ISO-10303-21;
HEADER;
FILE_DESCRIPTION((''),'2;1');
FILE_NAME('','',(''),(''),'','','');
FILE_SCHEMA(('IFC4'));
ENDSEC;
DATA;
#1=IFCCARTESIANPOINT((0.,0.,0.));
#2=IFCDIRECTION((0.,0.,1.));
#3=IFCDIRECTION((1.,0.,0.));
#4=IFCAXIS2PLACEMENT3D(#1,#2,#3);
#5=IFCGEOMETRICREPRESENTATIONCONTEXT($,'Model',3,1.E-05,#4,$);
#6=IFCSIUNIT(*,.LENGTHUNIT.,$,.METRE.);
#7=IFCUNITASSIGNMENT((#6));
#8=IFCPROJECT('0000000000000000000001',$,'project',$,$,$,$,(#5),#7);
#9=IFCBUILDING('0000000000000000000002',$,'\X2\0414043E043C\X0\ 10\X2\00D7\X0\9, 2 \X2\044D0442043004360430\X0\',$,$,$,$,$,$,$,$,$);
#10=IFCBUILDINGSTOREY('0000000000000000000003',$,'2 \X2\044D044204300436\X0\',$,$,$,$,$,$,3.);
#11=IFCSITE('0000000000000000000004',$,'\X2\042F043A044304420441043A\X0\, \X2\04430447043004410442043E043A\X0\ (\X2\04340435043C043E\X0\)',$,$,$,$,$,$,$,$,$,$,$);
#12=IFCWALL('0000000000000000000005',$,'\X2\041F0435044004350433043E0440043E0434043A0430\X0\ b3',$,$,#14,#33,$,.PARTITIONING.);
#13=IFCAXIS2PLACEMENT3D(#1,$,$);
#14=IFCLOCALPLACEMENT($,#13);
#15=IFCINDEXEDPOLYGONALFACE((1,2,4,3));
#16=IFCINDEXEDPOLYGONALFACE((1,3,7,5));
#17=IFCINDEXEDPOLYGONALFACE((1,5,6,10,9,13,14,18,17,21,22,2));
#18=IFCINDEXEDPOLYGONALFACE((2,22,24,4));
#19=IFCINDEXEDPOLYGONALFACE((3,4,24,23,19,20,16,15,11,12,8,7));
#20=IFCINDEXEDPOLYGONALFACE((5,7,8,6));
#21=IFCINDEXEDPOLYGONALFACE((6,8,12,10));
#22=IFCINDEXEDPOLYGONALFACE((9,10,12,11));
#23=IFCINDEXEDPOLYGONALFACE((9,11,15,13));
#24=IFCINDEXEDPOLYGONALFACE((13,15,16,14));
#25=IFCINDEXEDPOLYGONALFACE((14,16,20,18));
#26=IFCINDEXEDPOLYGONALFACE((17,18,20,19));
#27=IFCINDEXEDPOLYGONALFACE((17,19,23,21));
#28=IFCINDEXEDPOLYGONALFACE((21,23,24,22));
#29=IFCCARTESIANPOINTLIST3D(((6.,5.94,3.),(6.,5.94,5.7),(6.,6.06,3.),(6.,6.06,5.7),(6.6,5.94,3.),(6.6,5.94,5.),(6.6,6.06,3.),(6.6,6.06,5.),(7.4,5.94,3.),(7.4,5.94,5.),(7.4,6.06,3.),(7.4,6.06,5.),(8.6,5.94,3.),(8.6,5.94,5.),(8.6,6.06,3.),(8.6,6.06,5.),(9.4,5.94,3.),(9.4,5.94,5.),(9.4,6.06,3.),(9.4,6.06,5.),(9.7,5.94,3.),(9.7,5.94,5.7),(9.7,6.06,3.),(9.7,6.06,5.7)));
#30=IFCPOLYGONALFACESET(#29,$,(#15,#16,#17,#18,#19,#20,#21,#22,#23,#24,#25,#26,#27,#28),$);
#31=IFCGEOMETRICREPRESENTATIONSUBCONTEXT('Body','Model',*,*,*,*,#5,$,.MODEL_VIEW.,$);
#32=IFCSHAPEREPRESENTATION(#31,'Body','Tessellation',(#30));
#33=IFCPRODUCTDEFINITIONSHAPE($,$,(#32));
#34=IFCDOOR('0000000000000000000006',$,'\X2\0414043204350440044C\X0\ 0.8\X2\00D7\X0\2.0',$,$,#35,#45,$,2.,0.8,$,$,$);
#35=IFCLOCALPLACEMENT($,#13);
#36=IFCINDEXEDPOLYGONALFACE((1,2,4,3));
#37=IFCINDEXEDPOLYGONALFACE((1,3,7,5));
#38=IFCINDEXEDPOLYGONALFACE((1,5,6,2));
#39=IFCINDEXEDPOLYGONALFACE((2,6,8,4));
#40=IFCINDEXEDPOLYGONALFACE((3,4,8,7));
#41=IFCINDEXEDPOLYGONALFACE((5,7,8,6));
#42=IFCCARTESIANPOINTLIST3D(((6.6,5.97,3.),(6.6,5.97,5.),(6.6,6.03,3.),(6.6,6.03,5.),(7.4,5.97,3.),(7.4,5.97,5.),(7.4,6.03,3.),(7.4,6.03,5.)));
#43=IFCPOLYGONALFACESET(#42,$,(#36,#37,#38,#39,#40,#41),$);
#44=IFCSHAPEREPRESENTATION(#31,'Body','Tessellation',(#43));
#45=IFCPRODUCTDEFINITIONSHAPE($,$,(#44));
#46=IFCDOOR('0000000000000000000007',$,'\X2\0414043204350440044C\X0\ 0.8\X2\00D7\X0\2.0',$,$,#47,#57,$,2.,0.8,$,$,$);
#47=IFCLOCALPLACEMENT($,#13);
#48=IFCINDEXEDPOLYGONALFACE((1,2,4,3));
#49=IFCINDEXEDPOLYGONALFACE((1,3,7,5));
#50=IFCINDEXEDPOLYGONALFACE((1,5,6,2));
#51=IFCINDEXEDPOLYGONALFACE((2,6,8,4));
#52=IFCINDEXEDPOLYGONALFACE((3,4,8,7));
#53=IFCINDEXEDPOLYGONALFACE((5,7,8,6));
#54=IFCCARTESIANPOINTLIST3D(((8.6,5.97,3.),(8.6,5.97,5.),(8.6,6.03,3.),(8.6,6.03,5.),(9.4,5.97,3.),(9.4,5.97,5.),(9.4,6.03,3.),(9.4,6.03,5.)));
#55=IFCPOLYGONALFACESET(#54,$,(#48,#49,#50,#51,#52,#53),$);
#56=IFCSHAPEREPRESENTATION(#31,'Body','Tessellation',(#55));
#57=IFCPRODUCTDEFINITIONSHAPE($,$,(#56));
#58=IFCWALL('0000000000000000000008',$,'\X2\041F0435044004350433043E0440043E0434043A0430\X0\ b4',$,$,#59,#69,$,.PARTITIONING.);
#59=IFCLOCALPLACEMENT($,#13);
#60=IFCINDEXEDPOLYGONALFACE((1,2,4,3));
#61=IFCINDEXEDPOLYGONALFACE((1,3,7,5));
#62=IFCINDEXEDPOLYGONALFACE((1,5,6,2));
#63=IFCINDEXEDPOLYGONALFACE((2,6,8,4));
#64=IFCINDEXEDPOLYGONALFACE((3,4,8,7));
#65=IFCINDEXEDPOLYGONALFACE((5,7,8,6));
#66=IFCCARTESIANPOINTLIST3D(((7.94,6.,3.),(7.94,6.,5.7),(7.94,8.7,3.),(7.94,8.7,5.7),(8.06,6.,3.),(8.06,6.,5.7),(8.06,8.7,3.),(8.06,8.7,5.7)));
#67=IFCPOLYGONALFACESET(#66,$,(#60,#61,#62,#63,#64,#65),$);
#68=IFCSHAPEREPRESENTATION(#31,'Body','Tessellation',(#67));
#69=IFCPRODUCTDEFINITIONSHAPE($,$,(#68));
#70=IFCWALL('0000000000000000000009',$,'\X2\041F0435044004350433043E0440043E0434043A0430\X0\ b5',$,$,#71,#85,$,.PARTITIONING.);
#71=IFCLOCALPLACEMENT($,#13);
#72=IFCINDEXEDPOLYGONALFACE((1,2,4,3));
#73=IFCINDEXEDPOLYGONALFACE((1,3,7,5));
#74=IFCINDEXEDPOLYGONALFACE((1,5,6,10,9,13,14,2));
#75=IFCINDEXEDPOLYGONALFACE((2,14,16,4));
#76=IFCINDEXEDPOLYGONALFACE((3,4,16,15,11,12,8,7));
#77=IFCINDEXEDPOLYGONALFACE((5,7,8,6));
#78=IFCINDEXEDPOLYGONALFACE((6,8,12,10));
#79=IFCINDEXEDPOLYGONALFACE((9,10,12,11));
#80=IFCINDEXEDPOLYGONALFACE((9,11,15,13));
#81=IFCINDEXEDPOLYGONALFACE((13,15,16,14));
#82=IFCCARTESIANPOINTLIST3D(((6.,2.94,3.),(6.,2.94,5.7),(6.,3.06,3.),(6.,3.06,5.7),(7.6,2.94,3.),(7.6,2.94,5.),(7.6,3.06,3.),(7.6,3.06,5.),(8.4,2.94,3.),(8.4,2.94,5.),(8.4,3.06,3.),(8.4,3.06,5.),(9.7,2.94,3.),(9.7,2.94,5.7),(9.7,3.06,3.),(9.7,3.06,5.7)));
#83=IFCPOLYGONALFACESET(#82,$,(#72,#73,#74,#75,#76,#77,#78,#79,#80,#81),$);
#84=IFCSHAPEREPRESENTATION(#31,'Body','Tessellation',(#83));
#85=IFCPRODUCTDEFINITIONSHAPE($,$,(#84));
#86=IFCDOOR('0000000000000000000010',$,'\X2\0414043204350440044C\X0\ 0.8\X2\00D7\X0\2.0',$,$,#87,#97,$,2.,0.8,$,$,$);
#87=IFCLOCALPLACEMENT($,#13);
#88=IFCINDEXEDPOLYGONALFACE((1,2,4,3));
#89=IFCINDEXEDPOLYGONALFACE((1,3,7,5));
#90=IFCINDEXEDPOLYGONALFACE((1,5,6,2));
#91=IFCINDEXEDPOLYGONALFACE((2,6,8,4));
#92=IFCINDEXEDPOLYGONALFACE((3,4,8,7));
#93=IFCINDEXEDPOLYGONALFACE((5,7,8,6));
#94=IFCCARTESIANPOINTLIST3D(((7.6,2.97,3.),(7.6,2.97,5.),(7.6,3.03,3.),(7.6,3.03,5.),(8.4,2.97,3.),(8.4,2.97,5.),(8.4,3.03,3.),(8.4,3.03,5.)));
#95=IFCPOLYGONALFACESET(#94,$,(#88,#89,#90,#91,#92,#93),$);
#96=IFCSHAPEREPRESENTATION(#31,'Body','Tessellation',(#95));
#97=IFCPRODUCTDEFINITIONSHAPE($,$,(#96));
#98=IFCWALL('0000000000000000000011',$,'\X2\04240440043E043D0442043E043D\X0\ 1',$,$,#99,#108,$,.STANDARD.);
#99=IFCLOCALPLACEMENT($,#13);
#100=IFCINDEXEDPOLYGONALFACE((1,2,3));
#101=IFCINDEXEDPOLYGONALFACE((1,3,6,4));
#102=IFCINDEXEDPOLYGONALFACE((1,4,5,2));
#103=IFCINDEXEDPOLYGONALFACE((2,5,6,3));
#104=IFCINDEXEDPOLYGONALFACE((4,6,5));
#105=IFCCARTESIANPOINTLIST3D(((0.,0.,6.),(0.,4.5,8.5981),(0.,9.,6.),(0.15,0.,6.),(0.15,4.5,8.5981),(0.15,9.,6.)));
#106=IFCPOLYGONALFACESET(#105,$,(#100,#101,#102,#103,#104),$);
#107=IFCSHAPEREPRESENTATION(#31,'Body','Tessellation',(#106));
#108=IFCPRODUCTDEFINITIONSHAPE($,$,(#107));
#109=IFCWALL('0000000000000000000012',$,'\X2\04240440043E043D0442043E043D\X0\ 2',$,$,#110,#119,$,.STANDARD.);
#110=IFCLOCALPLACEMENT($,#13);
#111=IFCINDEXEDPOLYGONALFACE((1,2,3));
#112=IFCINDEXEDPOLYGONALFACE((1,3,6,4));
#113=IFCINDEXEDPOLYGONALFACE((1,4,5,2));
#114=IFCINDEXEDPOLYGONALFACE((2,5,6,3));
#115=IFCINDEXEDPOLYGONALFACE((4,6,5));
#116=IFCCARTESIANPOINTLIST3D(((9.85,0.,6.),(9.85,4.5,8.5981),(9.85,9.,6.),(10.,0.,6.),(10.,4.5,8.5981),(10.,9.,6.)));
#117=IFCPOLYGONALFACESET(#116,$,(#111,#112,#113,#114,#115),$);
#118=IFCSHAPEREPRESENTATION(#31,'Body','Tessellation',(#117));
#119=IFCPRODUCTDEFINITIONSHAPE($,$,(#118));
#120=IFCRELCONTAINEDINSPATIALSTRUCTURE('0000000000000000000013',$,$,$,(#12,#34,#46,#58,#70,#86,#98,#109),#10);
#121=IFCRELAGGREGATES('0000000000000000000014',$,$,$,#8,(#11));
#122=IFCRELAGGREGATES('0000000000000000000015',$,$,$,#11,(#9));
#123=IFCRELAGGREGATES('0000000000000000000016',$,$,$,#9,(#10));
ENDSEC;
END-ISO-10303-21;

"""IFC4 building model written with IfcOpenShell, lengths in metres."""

from ifc_helpers import new_model, si_unit, frame, origin_with_axes, place, context, subcontext, project, spatial, polyline, indexed_curve, outline, extrude, element, fill, save


model = new_model("IFC4")

# Units and contexts
model_context = context("Model", 3, precision=1e-05, world=origin_with_axes())
body_context = subcontext(model_context, "Body", "Model", "MODEL_VIEW")
ifc_project = project(units=[si_unit("LENGTHUNIT", "METRE")], contexts=[model_context])

# Site, building, storey
site = spatial("IfcSite", under=ifc_project, Name="Якутск, участок (демо)")
building = spatial("IfcBuilding", under=site, Name="Дом 10×9, 2 этажа")
storey = spatial("IfcBuildingStorey", under=building, Name="2 этаж", Elevation=3.0)

# Wall, openings, doors
wall_1_placement = place(None, frame((6.0, 5.94, 3.0), z_axis=(0.0, 0.0, 1.0), x_axis=(1.0, 0.0, 0.0)))
wall_1 = element("IfcWall", 1, at=wall_1_placement, inside=storey, Name="Перегородка b3", PredefinedType="PARTITIONING", context=body_context, shape_type="SweptSolid", body=[
    extrude(outline(indexed_curve([(0.0, 0.0), (0.0, 0.12), (3.7, 0.12), (3.7, 0.0), (0.0, 0.0)], self_intersect=False)), origin_with_axes(), (0.0, 0.0, 1.0), 2.7),
])
opening_1_placement = place(wall_1_placement, frame((0.6, -0.05, 0.0), z_axis=(0.0, 0.0, 1.0), x_axis=(1.0, 0.0, 0.0)))
opening_1 = element("IfcOpeningElement", 2, at=opening_1_placement, cuts=wall_1, context=body_context, shape_type="SweptSolid", body=[
    extrude(outline(indexed_curve([(0.0, 0.0), (0.0, 0.22), (0.8, 0.22), (0.8, 0.0), (0.0, 0.0)], self_intersect=False)), origin_with_axes(), (0.0, 0.0, 1.0), 2.0),
])
opening_2_placement = place(wall_1_placement, frame((2.6, -0.05, 0.0), z_axis=(0.0, 0.0, 1.0), x_axis=(1.0, 0.0, 0.0)))
opening_2 = element("IfcOpeningElement", 3, at=opening_2_placement, cuts=wall_1, context=body_context, shape_type="SweptSolid", body=[
    extrude(outline(indexed_curve([(0.0, 0.0), (0.0, 0.22), (0.8, 0.22), (0.8, 0.0), (0.0, 0.0)], self_intersect=False)), origin_with_axes(), (0.0, 0.0, 1.0), 2.0),
])
door_1_placement = place(opening_1_placement, frame((0.0, 0.08, 0.0), z_axis=(0.0, 0.0, 1.0), x_axis=(1.0, 0.0, 0.0)))
door_1 = element("IfcDoor", 4, at=door_1_placement, inside=storey, Name="Дверь 0.8×2.0", OverallHeight=2.0, OverallWidth=0.8, context=body_context, shape_type="SweptSolid", body=[
    extrude(outline(indexed_curve([(0.0, 0.0), (0.0, 0.06), (0.8, 0.06), (0.8, 0.0), (0.0, 0.0)], self_intersect=False)), origin_with_axes(), (0.0, 0.0, 1.0), 2.0),
])
fill(opening_1, door_1)
door_2_placement = place(opening_2_placement, frame((0.0, 0.08, 0.0), z_axis=(0.0, 0.0, 1.0), x_axis=(1.0, 0.0, 0.0)))
door_2 = element("IfcDoor", 5, at=door_2_placement, inside=storey, Name="Дверь 0.8×2.0", OverallHeight=2.0, OverallWidth=0.8, context=body_context, shape_type="SweptSolid", body=[
    extrude(outline(indexed_curve([(0.0, 0.0), (0.0, 0.06), (0.8, 0.06), (0.8, 0.0), (0.0, 0.0)], self_intersect=False)), origin_with_axes(), (0.0, 0.0, 1.0), 2.0),
])
fill(opening_2, door_2)

# Wall
wall_2_placement = place(None, frame((8.06, 6.0, 3.0), z_axis=(0.0, 0.0, 1.0), x_axis=(0.0, 1.0, 0.0)))
element("IfcWall", 6, at=wall_2_placement, inside=storey, Name="Перегородка b4", PredefinedType="PARTITIONING", context=body_context, shape_type="SweptSolid", body=[
    extrude(outline(indexed_curve([(0.0, 0.0), (0.0, 0.12), (2.7, 0.12), (2.7, 0.0), (0.0, 0.0)], self_intersect=False)), origin_with_axes(), (0.0, 0.0, 1.0), 2.7),
])

# Wall, opening, door
wall_3_placement = place(None, frame((6.0, 2.94, 3.0), z_axis=(0.0, 0.0, 1.0), x_axis=(1.0, 0.0, 0.0)))
wall_3 = element("IfcWall", 7, at=wall_3_placement, inside=storey, Name="Перегородка b5", PredefinedType="PARTITIONING", context=body_context, shape_type="SweptSolid", body=[
    extrude(outline(indexed_curve([(0.0, 0.0), (0.0, 0.12), (3.7, 0.12), (3.7, 0.0), (0.0, 0.0)], self_intersect=False)), origin_with_axes(), (0.0, 0.0, 1.0), 2.7),
])
opening_3_placement = place(wall_3_placement, frame((1.6, -0.05, 0.0), z_axis=(0.0, 0.0, 1.0), x_axis=(1.0, 0.0, 0.0)))
opening_3 = element("IfcOpeningElement", 8, at=opening_3_placement, cuts=wall_3, context=body_context, shape_type="SweptSolid", body=[
    extrude(outline(indexed_curve([(0.0, 0.0), (0.0, 0.22), (0.8, 0.22), (0.8, 0.0), (0.0, 0.0)], self_intersect=False)), origin_with_axes(), (0.0, 0.0, 1.0), 2.0),
])
door_3_placement = place(opening_3_placement, frame((0.0, 0.08, 0.0), z_axis=(0.0, 0.0, 1.0), x_axis=(1.0, 0.0, 0.0)))
door_3 = element("IfcDoor", 9, at=door_3_placement, inside=storey, Name="Дверь 0.8×2.0", OverallHeight=2.0, OverallWidth=0.8, context=body_context, shape_type="SweptSolid", body=[
    extrude(outline(indexed_curve([(0.0, 0.0), (0.0, 0.06), (0.8, 0.06), (0.8, 0.0), (0.0, 0.0)], self_intersect=False)), origin_with_axes(), (0.0, 0.0, 1.0), 2.0),
])
fill(opening_3, door_3)

# Walls
for number, where, z_axis, x_axis, name in (
    (10, (0.0, 0.0, 6.0), (1.0, 0.0, 0.0), (0.0, 1.0, 0.0), "Фронтон 1"),
    (11, (9.85, 0.0, 6.0), (1.0, 0.0, 0.0), (0.0, 1.0, 0.0), "Фронтон 2"),
):
    element("IfcWall", number, at=place(None, frame(where, z_axis=z_axis, x_axis=x_axis)), inside=storey, Name=name, PredefinedType="STANDARD", context=body_context, shape_type="SweptSolid", body=[
        extrude(outline(polyline([(0.0, 0.0), (9.0, 0.0), (4.5, 2.5981), (0.0, 0.0)])), origin_with_axes(), (0.0, 0.0, 1.0), 0.15),
    ])

save(model, "model.ifc")
